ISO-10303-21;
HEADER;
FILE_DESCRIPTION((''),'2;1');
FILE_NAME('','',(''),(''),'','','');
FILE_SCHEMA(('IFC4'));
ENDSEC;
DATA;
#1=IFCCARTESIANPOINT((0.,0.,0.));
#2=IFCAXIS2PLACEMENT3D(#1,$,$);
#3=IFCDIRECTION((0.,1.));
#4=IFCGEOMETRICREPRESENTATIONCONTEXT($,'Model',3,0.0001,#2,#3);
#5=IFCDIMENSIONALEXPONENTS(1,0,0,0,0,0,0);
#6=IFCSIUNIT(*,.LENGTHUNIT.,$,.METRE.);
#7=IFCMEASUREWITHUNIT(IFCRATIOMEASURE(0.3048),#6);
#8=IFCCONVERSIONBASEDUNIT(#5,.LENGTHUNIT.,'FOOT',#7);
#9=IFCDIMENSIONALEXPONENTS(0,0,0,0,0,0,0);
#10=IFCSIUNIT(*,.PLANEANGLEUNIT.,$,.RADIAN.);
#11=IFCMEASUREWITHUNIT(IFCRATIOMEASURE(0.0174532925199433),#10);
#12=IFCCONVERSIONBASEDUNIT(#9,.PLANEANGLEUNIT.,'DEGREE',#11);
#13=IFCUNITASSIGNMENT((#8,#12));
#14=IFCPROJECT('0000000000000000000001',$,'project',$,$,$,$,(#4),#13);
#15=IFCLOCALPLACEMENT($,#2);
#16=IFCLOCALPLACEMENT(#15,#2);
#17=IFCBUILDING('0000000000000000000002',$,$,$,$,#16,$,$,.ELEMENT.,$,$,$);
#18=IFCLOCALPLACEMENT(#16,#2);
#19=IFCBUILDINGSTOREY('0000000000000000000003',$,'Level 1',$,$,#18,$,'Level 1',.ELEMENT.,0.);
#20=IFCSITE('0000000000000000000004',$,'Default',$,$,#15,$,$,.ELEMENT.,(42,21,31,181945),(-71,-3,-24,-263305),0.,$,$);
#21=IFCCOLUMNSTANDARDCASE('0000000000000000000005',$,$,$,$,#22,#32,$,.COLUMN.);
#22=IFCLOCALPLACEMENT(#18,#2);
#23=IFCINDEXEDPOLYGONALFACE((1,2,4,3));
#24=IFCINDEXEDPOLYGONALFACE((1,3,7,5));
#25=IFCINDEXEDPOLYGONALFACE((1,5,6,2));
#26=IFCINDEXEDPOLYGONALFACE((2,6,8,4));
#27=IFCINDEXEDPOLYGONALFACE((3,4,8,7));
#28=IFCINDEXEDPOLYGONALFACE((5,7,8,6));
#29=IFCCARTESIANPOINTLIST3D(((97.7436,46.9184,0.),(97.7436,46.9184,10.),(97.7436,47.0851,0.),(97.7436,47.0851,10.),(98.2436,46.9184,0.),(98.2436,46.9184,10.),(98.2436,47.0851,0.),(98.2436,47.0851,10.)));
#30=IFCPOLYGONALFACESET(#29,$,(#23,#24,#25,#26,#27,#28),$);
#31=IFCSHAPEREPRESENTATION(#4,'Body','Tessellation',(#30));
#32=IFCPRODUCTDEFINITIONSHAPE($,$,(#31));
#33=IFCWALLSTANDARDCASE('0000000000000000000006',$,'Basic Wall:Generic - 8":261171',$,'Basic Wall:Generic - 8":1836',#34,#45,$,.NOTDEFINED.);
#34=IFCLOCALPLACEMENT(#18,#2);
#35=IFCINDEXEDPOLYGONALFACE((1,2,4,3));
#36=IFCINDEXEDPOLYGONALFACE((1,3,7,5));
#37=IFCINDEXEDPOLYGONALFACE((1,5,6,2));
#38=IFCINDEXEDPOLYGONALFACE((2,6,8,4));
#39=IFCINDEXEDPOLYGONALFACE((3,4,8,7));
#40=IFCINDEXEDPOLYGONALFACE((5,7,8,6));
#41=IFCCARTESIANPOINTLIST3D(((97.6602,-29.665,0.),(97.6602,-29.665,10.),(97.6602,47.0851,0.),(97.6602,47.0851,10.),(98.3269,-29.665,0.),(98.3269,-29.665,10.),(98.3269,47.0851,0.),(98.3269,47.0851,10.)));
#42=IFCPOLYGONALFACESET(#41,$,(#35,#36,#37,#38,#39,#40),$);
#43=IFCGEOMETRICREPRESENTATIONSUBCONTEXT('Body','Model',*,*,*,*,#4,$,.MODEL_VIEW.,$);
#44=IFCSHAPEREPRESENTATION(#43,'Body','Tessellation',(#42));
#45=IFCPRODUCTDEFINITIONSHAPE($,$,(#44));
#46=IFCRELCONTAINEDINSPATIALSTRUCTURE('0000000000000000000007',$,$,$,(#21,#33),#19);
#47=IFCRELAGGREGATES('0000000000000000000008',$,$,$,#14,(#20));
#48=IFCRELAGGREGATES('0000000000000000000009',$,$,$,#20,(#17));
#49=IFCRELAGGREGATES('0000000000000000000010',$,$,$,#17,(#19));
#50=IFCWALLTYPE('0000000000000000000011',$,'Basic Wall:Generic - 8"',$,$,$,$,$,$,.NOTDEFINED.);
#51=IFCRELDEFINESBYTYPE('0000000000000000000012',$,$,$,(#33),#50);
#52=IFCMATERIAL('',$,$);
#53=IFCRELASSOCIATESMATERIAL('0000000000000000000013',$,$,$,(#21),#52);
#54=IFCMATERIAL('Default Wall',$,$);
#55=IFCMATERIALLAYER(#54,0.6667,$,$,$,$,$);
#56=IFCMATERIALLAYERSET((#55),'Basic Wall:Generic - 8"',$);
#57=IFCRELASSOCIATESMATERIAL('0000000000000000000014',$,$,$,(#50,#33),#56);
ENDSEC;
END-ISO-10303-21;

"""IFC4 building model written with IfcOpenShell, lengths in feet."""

from ifc_helpers import new_model, entity, si_unit, converted_unit, direction, frame, frame_2d, origin, place, context, subcontext, project, spatial, rectangle, extrude, material, layer, layer_set, layer_usage, type_object, element, save


model = new_model("IFC4")

# Units and contexts
model_context = context("Model", 3, precision=0.0001, world=origin(), true_north=direction((0.0, 1.0)))
body_context = subcontext(model_context, "Body", "Model", "MODEL_VIEW")
ifc_project = project(units=[converted_unit("LENGTHUNIT", "FOOT", entity("IfcRatioMeasure", 0.3048), si_unit("LENGTHUNIT", "METRE"), dimensions=[1, 0, 0, 0, 0, 0, 0]), converted_unit("PLANEANGLEUNIT", "DEGREE", entity("IfcRatioMeasure", 0.0174532925199433), si_unit("PLANEANGLEUNIT", "RADIAN"), dimensions=[0, 0, 0, 0, 0, 0, 0])], contexts=[model_context])

# Site, building, storey
site_placement = place(None, origin())
site = spatial("IfcSite", under=ifc_project, at=site_placement, Name="Default", CompositionType="ELEMENT", RefLatitude=(42, 21, 31, 181945), RefLongitude=(-71, -3, -24, -263305), RefElevation=0.0)
building_placement = place(site_placement, origin())
building = spatial("IfcBuilding", under=site, at=building_placement, CompositionType="ELEMENT")
storey_placement = place(building_placement, origin())
storey = spatial("IfcBuildingStorey", under=building, at=storey_placement, Name="Level 1", LongName="Level 1", CompositionType="ELEMENT", Elevation=0.0)

# Column
ifc_material_1 = material(Name="")
wall_placement = place(storey_placement, frame((97.9936, 47.0851, 0.0), z_axis=(0.0, 0.0, 1.0), x_axis=(0.0, -1.0, 0.0)))
for number, where, z_axis, x_axis in (
    (1, (0.0833, 0.0, 0.0), (0.0, 0.0, 1.0), (1.0, 0.0, 0.0)),
):
    element("IfcColumnStandardCase", number, at=place(wall_placement, frame(where, z_axis=z_axis, x_axis=x_axis)), inside=storey, material=ifc_material_1, PredefinedType="COLUMN", context=model_context, shape_type="SweptSolid", body=[
        extrude(rectangle(XDim=0.1667, YDim=0.5), origin(), (0.0, 0.0, 1.0), 10.0),
    ])

# Wall
ifc_material_2 = material(Name="Default Wall")
ifc_layer = layer(ifc_material_2, 0.6667)
ifc_layer_set = layer_set([ifc_layer], Name="Basic Wall:Generic - 8\"")
ifc_layer_usage = layer_usage(ifc_layer_set, "AXIS2", "NEGATIVE", 0.3333)
wall_type = type_object("IfcWallType", Name="Basic Wall:Generic - 8\"", PredefinedType="NOTDEFINED", material=ifc_layer_set)
element("IfcWallStandardCase", 2, at=wall_placement, inside=storey, type_object=wall_type, material=ifc_layer_usage, Name="Basic Wall:Generic - 8\":261171", ObjectType="Basic Wall:Generic - 8\":1836", PredefinedType="NOTDEFINED", context=body_context, shape_type="SweptSolid", body=[
    extrude(rectangle(XDim=76.7501, YDim=0.6667, at=frame_2d((38.375, 0.0), x_axis=(-1.0, 0.0))), origin(), (0.0, 0.0, 1.0), 10.0),
])

save(model, "model.ifc")
